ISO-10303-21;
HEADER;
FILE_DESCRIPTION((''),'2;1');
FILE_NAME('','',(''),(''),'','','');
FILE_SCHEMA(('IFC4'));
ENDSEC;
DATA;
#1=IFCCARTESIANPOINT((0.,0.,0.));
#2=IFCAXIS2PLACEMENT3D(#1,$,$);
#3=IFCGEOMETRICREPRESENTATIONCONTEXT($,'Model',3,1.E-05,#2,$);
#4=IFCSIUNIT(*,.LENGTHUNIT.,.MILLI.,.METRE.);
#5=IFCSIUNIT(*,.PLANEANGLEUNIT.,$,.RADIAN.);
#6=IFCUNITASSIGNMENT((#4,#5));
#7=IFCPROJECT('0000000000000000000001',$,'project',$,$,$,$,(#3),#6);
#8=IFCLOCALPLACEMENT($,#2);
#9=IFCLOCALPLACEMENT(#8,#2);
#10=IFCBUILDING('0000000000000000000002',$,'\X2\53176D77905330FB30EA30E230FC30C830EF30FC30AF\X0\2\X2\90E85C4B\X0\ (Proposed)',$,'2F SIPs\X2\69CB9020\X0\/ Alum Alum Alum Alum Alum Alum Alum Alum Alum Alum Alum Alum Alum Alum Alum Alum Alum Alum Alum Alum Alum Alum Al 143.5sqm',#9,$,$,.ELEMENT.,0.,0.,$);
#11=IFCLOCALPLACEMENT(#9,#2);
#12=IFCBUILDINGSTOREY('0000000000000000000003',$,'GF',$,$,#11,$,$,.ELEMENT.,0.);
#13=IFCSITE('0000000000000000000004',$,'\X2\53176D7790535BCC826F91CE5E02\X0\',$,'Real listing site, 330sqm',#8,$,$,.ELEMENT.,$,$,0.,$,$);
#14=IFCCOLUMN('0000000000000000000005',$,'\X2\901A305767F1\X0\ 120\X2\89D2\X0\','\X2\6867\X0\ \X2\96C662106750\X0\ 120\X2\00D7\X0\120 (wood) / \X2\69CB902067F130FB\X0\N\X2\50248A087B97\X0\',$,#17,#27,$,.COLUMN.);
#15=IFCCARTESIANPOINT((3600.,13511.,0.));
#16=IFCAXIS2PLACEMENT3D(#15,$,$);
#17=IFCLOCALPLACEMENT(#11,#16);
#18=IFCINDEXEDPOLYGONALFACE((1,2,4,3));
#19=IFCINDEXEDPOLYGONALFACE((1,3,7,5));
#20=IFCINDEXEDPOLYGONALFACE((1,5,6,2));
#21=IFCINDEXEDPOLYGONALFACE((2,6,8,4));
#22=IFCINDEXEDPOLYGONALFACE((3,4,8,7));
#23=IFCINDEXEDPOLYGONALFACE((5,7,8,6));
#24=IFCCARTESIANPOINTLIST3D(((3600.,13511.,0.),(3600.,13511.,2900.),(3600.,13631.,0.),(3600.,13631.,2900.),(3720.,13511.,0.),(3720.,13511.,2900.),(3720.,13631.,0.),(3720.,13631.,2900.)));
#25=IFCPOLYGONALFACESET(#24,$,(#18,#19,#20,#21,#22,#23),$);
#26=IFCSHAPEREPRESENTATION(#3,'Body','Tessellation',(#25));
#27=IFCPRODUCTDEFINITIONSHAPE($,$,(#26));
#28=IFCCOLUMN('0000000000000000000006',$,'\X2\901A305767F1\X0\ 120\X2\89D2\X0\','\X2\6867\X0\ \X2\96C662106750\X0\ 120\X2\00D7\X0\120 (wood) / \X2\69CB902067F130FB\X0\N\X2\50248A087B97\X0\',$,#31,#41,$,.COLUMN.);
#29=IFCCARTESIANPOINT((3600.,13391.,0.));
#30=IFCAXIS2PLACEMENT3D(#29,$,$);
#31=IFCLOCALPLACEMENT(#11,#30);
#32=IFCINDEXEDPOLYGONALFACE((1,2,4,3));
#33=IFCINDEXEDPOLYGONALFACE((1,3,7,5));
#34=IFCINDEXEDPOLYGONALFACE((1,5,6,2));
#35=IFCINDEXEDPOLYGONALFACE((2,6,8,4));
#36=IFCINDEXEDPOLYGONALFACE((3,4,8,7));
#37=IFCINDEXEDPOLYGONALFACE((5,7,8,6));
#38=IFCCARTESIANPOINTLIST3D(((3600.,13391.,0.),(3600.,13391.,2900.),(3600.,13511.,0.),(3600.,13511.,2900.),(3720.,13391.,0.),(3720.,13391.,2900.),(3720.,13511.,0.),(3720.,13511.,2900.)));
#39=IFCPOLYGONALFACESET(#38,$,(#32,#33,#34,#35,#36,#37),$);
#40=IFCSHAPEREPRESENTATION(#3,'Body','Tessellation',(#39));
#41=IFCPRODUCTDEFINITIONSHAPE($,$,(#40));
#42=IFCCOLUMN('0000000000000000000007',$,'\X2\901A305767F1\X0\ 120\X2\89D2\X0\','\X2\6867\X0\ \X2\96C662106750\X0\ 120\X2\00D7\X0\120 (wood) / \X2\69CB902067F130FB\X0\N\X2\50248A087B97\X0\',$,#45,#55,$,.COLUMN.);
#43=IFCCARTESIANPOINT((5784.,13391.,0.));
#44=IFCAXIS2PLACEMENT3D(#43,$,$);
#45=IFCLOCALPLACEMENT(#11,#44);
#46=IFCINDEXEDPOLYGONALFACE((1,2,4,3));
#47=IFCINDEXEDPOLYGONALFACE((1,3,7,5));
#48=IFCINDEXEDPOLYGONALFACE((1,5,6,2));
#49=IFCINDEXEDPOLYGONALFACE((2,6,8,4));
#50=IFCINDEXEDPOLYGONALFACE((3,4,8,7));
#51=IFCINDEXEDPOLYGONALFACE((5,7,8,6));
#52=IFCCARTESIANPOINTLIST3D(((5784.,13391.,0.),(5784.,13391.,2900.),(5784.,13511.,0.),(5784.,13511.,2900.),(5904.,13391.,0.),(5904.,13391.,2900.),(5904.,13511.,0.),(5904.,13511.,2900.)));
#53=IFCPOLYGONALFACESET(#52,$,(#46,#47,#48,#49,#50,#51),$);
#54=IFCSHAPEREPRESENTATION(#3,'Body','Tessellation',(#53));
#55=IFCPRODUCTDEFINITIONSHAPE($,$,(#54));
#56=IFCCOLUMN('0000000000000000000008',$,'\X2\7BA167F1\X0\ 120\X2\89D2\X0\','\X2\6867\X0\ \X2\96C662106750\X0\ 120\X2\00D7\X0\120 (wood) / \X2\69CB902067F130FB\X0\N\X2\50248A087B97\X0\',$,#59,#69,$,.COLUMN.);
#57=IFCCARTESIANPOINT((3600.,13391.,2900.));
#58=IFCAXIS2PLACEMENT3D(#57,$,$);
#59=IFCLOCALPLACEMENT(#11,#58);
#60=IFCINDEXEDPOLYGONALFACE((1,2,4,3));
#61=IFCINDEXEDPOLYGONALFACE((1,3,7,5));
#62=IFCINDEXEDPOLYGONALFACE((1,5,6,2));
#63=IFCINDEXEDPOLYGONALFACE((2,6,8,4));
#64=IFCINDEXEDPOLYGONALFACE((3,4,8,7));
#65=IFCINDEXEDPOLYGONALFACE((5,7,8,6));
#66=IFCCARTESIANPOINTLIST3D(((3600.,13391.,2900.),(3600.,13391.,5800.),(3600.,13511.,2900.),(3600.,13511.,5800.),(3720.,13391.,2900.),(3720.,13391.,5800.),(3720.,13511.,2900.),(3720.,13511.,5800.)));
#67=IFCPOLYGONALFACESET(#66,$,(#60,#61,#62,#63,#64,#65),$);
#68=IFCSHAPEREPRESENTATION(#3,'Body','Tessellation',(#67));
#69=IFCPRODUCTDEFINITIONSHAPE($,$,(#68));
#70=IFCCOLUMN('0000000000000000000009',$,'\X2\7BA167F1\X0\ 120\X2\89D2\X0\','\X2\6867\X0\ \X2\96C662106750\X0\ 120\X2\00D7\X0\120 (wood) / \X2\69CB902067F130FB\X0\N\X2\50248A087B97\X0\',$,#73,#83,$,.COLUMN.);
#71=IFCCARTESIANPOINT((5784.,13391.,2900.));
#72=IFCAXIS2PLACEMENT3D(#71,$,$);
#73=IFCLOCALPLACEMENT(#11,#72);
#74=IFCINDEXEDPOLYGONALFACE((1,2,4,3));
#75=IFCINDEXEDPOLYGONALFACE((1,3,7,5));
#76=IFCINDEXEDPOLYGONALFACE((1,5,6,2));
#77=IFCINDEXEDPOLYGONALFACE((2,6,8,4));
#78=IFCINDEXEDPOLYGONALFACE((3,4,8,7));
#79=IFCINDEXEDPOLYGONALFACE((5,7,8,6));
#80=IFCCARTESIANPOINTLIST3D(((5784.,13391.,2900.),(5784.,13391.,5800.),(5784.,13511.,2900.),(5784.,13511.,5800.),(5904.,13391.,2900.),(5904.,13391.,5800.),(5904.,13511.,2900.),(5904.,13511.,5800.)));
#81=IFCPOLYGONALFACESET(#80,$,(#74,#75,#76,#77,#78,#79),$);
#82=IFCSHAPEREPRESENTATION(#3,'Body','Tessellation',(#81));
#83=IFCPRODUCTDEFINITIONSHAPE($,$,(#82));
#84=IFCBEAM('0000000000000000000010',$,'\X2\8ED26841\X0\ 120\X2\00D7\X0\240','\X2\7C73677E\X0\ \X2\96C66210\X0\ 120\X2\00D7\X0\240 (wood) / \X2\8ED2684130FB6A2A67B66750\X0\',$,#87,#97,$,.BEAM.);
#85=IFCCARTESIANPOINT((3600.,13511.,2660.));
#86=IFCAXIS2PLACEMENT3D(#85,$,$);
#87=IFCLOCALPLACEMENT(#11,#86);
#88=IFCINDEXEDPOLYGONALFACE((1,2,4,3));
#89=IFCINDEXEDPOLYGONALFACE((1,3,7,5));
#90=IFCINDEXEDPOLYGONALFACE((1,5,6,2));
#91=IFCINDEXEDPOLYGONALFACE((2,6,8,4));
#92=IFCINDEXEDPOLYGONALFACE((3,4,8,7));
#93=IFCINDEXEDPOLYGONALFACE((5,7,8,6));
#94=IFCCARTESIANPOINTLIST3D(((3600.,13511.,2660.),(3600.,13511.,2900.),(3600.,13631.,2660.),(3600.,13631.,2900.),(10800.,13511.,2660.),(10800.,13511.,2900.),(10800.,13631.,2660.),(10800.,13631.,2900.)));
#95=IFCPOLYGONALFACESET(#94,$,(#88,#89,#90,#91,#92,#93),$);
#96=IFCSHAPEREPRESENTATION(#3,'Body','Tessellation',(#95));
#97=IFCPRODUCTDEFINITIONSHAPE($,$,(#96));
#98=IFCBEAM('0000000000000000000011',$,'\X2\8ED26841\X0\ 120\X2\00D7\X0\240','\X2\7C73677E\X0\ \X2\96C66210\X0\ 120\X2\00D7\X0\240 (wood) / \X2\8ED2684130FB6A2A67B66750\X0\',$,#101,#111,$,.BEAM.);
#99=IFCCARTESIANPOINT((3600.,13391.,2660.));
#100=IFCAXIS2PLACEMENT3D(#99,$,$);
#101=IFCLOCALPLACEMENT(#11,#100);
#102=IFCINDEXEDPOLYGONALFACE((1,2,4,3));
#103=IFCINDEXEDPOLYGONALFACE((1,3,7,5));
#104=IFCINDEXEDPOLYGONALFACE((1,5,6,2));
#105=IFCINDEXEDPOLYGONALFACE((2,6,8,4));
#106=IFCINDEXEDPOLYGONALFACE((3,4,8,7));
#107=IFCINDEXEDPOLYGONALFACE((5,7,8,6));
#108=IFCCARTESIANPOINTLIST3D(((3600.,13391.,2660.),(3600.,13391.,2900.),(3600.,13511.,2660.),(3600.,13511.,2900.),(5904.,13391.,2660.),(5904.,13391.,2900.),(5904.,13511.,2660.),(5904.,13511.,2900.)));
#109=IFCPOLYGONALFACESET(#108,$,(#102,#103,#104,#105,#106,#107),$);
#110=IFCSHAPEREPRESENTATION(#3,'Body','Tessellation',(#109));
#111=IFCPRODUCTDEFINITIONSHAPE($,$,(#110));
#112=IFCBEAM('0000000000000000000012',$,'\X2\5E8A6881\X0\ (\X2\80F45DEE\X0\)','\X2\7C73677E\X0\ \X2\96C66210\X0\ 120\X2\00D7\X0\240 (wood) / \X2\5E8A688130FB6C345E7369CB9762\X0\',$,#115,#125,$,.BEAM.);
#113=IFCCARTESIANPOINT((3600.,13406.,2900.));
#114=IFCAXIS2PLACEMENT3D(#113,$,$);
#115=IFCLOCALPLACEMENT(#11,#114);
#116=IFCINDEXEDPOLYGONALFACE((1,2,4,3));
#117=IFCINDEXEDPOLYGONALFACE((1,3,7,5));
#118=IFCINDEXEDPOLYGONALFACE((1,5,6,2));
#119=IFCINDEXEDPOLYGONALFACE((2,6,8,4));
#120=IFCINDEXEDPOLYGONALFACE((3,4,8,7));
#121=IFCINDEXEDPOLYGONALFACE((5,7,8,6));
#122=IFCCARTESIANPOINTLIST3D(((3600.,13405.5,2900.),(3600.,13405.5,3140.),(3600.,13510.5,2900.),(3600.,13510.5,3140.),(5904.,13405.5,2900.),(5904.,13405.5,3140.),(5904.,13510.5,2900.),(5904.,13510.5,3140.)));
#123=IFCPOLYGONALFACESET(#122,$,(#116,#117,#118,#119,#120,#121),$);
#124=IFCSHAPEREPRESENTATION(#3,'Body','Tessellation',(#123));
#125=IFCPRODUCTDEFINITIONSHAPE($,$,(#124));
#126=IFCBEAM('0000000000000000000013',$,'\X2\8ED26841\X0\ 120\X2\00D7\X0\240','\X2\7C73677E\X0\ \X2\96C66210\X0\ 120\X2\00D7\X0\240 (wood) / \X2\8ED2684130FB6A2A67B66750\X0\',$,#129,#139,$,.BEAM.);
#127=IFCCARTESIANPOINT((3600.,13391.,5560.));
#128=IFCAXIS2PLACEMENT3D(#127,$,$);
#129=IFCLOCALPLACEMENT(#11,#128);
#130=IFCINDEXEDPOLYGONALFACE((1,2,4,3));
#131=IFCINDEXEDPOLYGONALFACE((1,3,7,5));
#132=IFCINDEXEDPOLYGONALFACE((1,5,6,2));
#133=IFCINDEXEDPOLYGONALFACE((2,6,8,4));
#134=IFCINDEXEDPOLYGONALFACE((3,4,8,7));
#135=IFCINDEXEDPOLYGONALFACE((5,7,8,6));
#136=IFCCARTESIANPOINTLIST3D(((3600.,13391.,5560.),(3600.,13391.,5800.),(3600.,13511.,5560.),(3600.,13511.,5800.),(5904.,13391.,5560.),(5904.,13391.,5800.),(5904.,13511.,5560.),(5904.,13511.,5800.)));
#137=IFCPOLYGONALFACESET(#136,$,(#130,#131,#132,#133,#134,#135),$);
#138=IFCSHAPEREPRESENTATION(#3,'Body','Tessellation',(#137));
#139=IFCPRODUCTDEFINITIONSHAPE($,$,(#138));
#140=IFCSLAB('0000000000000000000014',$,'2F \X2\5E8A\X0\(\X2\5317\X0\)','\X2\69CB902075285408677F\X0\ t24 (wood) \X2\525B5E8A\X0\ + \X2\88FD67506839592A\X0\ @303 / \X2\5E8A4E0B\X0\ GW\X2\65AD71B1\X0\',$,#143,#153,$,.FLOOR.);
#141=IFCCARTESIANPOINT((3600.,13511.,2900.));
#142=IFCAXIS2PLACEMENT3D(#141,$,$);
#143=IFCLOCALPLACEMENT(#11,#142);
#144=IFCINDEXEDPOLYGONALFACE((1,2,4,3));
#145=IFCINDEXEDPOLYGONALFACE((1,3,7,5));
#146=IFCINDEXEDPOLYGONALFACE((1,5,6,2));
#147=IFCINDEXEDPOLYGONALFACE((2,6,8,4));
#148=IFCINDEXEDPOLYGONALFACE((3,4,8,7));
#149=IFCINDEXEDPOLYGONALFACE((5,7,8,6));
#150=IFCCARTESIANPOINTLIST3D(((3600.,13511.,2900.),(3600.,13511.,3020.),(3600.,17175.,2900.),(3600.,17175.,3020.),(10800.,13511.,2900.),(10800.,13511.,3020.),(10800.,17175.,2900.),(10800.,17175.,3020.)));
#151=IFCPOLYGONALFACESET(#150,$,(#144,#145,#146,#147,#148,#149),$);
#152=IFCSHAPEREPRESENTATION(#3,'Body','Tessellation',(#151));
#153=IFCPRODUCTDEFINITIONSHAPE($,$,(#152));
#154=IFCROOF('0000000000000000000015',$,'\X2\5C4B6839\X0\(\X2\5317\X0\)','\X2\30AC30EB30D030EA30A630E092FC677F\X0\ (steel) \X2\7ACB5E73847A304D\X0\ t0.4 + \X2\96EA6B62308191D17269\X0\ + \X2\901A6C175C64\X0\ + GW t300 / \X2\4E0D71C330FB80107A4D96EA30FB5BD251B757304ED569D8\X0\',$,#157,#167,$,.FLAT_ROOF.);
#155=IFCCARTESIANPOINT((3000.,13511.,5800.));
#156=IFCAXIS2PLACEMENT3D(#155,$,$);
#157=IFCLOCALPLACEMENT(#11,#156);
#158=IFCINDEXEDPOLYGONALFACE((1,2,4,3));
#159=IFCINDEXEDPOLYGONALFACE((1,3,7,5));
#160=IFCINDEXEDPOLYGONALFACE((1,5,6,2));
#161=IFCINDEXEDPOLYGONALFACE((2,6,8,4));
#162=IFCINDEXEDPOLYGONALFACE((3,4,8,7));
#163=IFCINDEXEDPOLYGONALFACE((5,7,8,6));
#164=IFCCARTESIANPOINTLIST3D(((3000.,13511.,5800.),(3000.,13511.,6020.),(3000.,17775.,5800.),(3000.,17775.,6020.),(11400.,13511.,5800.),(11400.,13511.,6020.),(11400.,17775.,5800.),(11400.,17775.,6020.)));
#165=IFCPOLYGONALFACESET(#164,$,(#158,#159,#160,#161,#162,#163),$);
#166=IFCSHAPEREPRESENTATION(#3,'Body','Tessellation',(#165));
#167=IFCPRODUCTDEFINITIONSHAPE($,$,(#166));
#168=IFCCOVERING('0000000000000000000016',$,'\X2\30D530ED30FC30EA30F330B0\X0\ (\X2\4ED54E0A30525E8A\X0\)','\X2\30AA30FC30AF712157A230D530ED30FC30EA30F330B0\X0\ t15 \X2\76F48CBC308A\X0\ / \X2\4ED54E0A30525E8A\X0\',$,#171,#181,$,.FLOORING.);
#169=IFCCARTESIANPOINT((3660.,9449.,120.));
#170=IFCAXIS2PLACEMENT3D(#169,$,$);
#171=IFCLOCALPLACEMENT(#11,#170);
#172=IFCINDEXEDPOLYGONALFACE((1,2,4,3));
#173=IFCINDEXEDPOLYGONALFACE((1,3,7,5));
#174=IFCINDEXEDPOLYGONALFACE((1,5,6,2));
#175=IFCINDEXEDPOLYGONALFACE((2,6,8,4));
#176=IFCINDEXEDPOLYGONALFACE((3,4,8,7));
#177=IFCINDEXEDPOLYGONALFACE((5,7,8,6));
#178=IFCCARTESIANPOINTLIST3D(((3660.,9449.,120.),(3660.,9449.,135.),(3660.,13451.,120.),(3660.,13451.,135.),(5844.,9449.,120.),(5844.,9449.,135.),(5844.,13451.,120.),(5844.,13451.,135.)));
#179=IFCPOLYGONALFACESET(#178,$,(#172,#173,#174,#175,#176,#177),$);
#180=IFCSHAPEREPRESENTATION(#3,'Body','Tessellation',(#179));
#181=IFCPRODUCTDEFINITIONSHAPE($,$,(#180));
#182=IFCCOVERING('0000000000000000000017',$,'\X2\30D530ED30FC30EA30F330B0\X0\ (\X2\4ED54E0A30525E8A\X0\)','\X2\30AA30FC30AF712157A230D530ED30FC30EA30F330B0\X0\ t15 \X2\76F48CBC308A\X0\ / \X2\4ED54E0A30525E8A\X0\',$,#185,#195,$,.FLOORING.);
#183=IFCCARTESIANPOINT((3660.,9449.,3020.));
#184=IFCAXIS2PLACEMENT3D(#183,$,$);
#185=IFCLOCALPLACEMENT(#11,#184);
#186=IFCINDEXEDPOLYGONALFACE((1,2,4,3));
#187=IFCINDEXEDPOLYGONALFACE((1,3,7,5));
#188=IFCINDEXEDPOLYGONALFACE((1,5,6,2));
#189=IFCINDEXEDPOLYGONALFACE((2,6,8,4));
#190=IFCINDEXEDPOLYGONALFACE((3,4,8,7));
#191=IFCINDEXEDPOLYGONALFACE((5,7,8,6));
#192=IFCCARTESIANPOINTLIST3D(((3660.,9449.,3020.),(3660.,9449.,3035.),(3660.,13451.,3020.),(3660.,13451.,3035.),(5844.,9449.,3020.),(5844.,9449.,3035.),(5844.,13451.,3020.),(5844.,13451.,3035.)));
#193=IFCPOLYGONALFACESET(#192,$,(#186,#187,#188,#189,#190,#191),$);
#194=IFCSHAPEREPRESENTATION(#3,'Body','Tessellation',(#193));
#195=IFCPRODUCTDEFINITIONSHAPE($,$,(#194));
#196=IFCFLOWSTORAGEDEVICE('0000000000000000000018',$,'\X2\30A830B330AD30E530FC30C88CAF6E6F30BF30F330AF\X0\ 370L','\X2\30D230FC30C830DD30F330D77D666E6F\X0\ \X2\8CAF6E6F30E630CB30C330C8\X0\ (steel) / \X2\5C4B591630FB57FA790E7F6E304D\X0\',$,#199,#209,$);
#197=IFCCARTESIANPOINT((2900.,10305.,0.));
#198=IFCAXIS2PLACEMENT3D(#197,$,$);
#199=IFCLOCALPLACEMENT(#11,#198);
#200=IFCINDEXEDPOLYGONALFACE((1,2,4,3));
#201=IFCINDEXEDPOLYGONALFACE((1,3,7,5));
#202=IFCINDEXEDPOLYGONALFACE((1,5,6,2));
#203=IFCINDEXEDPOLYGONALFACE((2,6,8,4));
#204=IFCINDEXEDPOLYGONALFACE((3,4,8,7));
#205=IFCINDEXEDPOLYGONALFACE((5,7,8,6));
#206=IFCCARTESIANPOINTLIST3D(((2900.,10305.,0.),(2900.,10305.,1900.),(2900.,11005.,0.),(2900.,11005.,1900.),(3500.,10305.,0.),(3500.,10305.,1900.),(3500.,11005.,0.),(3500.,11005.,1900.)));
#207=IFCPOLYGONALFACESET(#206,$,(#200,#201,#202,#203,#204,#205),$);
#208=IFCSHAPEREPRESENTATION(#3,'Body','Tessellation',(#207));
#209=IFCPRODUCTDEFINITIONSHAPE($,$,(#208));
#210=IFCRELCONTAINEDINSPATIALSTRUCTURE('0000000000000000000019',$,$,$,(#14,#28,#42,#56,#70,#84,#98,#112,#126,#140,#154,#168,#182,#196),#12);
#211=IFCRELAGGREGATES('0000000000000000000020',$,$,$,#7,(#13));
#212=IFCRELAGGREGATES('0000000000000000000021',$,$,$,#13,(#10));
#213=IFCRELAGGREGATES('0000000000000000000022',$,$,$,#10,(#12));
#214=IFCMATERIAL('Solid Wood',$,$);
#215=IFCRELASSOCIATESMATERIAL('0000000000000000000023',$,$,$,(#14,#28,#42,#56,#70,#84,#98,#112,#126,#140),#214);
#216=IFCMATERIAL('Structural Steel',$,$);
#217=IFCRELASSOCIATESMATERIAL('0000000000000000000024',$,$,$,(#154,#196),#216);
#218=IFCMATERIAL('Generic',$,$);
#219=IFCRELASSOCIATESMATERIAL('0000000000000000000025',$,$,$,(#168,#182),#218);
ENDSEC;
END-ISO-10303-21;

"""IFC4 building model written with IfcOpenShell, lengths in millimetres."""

from ifc_helpers import new_model, si_unit, frame, frame_2d, origin, place, context, project, spatial, rectangle, extrude, material, element, save


model = new_model("IFC4")

# Units and contexts
model_context = context("Model", 3, precision=1e-05, world=origin())
ifc_project = project(units=[si_unit("LENGTHUNIT", "METRE", prefix="MILLI"), si_unit("PLANEANGLEUNIT", "RADIAN")], contexts=[model_context])

# Site, building, storey
site_placement = place(None, origin())
site = spatial("IfcSite", under=ifc_project, at=site_placement, Name="北海道富良野市", ObjectType="Real listing site, 330sqm", CompositionType="ELEMENT", RefElevation=0.0)
building_placement = place(site_placement, origin())
building = spatial("IfcBuilding", under=site, at=building_placement, Name="北海道・リモートワーク2部屋 (Proposed)", ObjectType="2F SIPs構造/ Alum Alum Alum Alum Alum Alum Alum Alum Alum Alum Alum Alum Alum Alum Alum Alum Alum Alum Alum Alum Alum Alum Al 143.5sqm", CompositionType="ELEMENT", ElevationOfRefHeight=0.0, ElevationOfTerrain=0.0)
storey_placement = place(building_placement, origin())
storey = spatial("IfcBuildingStorey", under=building, at=storey_placement, Name="GF", CompositionType="ELEMENT", Elevation=0.0)

# Columns
ifc_material_1 = material(Name="Solid Wood")
column_1_placement = place(storey_placement, frame((3600.0, 13511.0, 0.0)))
element("IfcColumn", 1, at=column_1_placement, inside=storey, material=ifc_material_1, Name="通し柱 120角", Description="桧 集成材 120×120 (wood) / 構造柱・N値計算", PredefinedType="COLUMN", context=model_context, shape_type="SweptSolid", body=[
    extrude(rectangle(XDim=120.0, YDim=120.0, at=frame_2d((60.0, 60.0))), frame((3600.0, 13511.0, 0.0)), (0.0, 0.0, 1.0), 2900.0),
])
column_2_placement = place(storey_placement, frame((3600.0, 13391.0, 0.0)))
element("IfcColumn", 2, at=column_2_placement, inside=storey, material=ifc_material_1, Name="通し柱 120角", Description="桧 集成材 120×120 (wood) / 構造柱・N値計算", PredefinedType="COLUMN", context=model_context, shape_type="SweptSolid", body=[
    extrude(rectangle(XDim=120.0, YDim=120.0, at=frame_2d((60.0, 60.0))), frame((3600.0, 13391.0, 0.0)), (0.0, 0.0, 1.0), 2900.0),
])
column_3_placement = place(storey_placement, frame((5784.0, 13391.0, 0.0)))
element("IfcColumn", 3, at=column_3_placement, inside=storey, material=ifc_material_1, Name="通し柱 120角", Description="桧 集成材 120×120 (wood) / 構造柱・N値計算", PredefinedType="COLUMN", context=model_context, shape_type="SweptSolid", body=[
    extrude(rectangle(XDim=120.0, YDim=120.0, at=frame_2d((60.0, 60.0))), frame((5784.0, 13391.0, 0.0)), (0.0, 0.0, 1.0), 2900.0),
])
column_4_placement = place(storey_placement, frame((3600.0, 13391.0, 2900.0)))
element("IfcColumn", 4, at=column_4_placement, inside=storey, material=ifc_material_1, Name="管柱 120角", Description="桧 集成材 120×120 (wood) / 構造柱・N値計算", PredefinedType="COLUMN", context=model_context, shape_type="SweptSolid", body=[
    extrude(rectangle(XDim=120.0, YDim=120.0, at=frame_2d((60.0, 60.0))), frame((3600.0, 13391.0, 2900.0)), (0.0, 0.0, 1.0), 2900.0),
])
column_5_placement = place(storey_placement, frame((5784.0, 13391.0, 2900.0)))
element("IfcColumn", 5, at=column_5_placement, inside=storey, material=ifc_material_1, Name="管柱 120角", Description="桧 集成材 120×120 (wood) / 構造柱・N値計算", PredefinedType="COLUMN", context=model_context, shape_type="SweptSolid", body=[
    extrude(rectangle(XDim=120.0, YDim=120.0, at=frame_2d((60.0, 60.0))), frame((5784.0, 13391.0, 2900.0)), (0.0, 0.0, 1.0), 2900.0),
])

# Beams
beam_1_placement = place(storey_placement, frame((3600.0, 13511.0, 2660.0)))
element("IfcBeam", 6, at=beam_1_placement, inside=storey, material=ifc_material_1, Name="軒桁 120×240", Description="米松 集成 120×240 (wood) / 軒桁・横架材", PredefinedType="BEAM", context=model_context, shape_type="SweptSolid", body=[
    extrude(rectangle(XDim=7200.0, YDim=120.0, at=frame_2d((3600.0, 60.0))), frame((3600.0, 13511.0, 2660.0)), (0.0, 0.0, 1.0), 240.0),
])
beam_2_placement = place(storey_placement, frame((3600.0, 13391.0, 2660.0)))
element("IfcBeam", 7, at=beam_2_placement, inside=storey, material=ifc_material_1, Name="軒桁 120×240", Description="米松 集成 120×240 (wood) / 軒桁・横架材", PredefinedType="BEAM", context=model_context, shape_type="SweptSolid", body=[
    extrude(rectangle(XDim=2304.0, YDim=120.0, at=frame_2d((1152.0, 60.0))), frame((3600.0, 13391.0, 2660.0)), (0.0, 0.0, 1.0), 240.0),
])
beam_3_placement = place(storey_placement, frame((3600.0, 13406.0, 2900.0)))
element("IfcBeam", 8, at=beam_3_placement, inside=storey, material=ifc_material_1, Name="床梁 (胴差)", Description="米松 集成 120×240 (wood) / 床梁・水平構面", PredefinedType="BEAM", context=model_context, shape_type="SweptSolid", body=[
    extrude(rectangle(XDim=2304.0, YDim=105.0, at=frame_2d((1152.0, 52.0))), frame((3600.0, 13406.0, 2900.0)), (0.0, 0.0, 1.0), 240.0),
])
beam_4_placement = place(storey_placement, frame((3600.0, 13391.0, 5560.0)))
element("IfcBeam", 9, at=beam_4_placement, inside=storey, material=ifc_material_1, Name="軒桁 120×240", Description="米松 集成 120×240 (wood) / 軒桁・横架材", PredefinedType="BEAM", context=model_context, shape_type="SweptSolid", body=[
    extrude(rectangle(XDim=2304.0, YDim=120.0, at=frame_2d((1152.0, 60.0))), frame((3600.0, 13391.0, 5560.0)), (0.0, 0.0, 1.0), 240.0),
])

# Slab
slab_1_placement = place(storey_placement, frame((3600.0, 13511.0, 2900.0)))
element("IfcSlab", 10, at=slab_1_placement, inside=storey, material=ifc_material_1, Name="2F 床(北)", Description="構造用合板 t24 (wood) 剛床 + 製材根太 @303 / 床下 GW断熱", PredefinedType="FLOOR", context=model_context, shape_type="SweptSolid", body=[
    extrude(rectangle(XDim=7200.0, YDim=3664.0, at=frame_2d((3600.0, 1832.0))), frame((3600.0, 13511.0, 2900.0)), (0.0, 0.0, 1.0), 120.0),
])

# Roof
ifc_material_2 = material(Name="Structural Steel")
for number, where, name in (
    (11, (3000.0, 13511.0, 5800.0), "屋根(北)"),
):
    element("IfcRoof", number, at=place(storey_placement, frame(where)), inside=storey, material=ifc_material_2, Name=name, Description="ガルバリウム鋼板 (steel) 立平葺き t0.4 + 雪止め金物 + 通気層 + GW t300 / 不燃・耐積雪・寒冷地仕様", PredefinedType="FLAT_ROOF", context=model_context, shape_type="SweptSolid", body=[
        extrude(rectangle(XDim=8400.0, YDim=4264.0, at=frame_2d((4200.0, 2132.0))), frame((3000.0, 13511.0, 5800.0)), (0.0, 0.0, 1.0), 220.0),
    ])

# Coverings
ifc_material_3 = material(Name="Generic")
covering_1_placement = place(storey_placement, frame((3660.0, 9449.0, 120.0)))
element("IfcCovering", 12, at=covering_1_placement, inside=storey, material=ifc_material_3, Name="フローリング (仕上げ床)", Description="オーク無垢フローリング t15 直貼り / 仕上げ床", PredefinedType="FLOORING", context=model_context, shape_type="SweptSolid", body=[
    extrude(rectangle(XDim=2184.0, YDim=4002.0, at=frame_2d((1092.0, 2001.0))), frame((3660.0, 9449.0, 120.0)), (0.0, 0.0, 1.0), 15.0),
])
covering_2_placement = place(storey_placement, frame((3660.0, 9449.0, 3020.0)))
element("IfcCovering", 13, at=covering_2_placement, inside=storey, material=ifc_material_3, Name="フローリング (仕上げ床)", Description="オーク無垢フローリング t15 直貼り / 仕上げ床", PredefinedType="FLOORING", context=model_context, shape_type="SweptSolid", body=[
    extrude(rectangle(XDim=2184.0, YDim=4002.0, at=frame_2d((1092.0, 2001.0))), frame((3660.0, 9449.0, 3020.0)), (0.0, 0.0, 1.0), 15.0),
])

# Flow storage device
flow_storage_device_placement = place(storey_placement, frame((2900.0, 10305.0, 0.0)))
element("IfcFlowStorageDevice", 14, at=flow_storage_device_placement, inside=storey, material=ifc_material_2, Name="エコキュート貯湯タンク 370L", Description="ヒートポンプ給湯 貯湯ユニット (steel) / 屋外・基礎置き", context=model_context, shape_type="SweptSolid", body=[
    extrude(rectangle(XDim=600.0, YDim=700.0, at=frame_2d((300.0, 350.0))), frame((2900.0, 10305.0, 0.0)), (0.0, 0.0, 1.0), 1900.0),
])

save(model, "model.ifc")
